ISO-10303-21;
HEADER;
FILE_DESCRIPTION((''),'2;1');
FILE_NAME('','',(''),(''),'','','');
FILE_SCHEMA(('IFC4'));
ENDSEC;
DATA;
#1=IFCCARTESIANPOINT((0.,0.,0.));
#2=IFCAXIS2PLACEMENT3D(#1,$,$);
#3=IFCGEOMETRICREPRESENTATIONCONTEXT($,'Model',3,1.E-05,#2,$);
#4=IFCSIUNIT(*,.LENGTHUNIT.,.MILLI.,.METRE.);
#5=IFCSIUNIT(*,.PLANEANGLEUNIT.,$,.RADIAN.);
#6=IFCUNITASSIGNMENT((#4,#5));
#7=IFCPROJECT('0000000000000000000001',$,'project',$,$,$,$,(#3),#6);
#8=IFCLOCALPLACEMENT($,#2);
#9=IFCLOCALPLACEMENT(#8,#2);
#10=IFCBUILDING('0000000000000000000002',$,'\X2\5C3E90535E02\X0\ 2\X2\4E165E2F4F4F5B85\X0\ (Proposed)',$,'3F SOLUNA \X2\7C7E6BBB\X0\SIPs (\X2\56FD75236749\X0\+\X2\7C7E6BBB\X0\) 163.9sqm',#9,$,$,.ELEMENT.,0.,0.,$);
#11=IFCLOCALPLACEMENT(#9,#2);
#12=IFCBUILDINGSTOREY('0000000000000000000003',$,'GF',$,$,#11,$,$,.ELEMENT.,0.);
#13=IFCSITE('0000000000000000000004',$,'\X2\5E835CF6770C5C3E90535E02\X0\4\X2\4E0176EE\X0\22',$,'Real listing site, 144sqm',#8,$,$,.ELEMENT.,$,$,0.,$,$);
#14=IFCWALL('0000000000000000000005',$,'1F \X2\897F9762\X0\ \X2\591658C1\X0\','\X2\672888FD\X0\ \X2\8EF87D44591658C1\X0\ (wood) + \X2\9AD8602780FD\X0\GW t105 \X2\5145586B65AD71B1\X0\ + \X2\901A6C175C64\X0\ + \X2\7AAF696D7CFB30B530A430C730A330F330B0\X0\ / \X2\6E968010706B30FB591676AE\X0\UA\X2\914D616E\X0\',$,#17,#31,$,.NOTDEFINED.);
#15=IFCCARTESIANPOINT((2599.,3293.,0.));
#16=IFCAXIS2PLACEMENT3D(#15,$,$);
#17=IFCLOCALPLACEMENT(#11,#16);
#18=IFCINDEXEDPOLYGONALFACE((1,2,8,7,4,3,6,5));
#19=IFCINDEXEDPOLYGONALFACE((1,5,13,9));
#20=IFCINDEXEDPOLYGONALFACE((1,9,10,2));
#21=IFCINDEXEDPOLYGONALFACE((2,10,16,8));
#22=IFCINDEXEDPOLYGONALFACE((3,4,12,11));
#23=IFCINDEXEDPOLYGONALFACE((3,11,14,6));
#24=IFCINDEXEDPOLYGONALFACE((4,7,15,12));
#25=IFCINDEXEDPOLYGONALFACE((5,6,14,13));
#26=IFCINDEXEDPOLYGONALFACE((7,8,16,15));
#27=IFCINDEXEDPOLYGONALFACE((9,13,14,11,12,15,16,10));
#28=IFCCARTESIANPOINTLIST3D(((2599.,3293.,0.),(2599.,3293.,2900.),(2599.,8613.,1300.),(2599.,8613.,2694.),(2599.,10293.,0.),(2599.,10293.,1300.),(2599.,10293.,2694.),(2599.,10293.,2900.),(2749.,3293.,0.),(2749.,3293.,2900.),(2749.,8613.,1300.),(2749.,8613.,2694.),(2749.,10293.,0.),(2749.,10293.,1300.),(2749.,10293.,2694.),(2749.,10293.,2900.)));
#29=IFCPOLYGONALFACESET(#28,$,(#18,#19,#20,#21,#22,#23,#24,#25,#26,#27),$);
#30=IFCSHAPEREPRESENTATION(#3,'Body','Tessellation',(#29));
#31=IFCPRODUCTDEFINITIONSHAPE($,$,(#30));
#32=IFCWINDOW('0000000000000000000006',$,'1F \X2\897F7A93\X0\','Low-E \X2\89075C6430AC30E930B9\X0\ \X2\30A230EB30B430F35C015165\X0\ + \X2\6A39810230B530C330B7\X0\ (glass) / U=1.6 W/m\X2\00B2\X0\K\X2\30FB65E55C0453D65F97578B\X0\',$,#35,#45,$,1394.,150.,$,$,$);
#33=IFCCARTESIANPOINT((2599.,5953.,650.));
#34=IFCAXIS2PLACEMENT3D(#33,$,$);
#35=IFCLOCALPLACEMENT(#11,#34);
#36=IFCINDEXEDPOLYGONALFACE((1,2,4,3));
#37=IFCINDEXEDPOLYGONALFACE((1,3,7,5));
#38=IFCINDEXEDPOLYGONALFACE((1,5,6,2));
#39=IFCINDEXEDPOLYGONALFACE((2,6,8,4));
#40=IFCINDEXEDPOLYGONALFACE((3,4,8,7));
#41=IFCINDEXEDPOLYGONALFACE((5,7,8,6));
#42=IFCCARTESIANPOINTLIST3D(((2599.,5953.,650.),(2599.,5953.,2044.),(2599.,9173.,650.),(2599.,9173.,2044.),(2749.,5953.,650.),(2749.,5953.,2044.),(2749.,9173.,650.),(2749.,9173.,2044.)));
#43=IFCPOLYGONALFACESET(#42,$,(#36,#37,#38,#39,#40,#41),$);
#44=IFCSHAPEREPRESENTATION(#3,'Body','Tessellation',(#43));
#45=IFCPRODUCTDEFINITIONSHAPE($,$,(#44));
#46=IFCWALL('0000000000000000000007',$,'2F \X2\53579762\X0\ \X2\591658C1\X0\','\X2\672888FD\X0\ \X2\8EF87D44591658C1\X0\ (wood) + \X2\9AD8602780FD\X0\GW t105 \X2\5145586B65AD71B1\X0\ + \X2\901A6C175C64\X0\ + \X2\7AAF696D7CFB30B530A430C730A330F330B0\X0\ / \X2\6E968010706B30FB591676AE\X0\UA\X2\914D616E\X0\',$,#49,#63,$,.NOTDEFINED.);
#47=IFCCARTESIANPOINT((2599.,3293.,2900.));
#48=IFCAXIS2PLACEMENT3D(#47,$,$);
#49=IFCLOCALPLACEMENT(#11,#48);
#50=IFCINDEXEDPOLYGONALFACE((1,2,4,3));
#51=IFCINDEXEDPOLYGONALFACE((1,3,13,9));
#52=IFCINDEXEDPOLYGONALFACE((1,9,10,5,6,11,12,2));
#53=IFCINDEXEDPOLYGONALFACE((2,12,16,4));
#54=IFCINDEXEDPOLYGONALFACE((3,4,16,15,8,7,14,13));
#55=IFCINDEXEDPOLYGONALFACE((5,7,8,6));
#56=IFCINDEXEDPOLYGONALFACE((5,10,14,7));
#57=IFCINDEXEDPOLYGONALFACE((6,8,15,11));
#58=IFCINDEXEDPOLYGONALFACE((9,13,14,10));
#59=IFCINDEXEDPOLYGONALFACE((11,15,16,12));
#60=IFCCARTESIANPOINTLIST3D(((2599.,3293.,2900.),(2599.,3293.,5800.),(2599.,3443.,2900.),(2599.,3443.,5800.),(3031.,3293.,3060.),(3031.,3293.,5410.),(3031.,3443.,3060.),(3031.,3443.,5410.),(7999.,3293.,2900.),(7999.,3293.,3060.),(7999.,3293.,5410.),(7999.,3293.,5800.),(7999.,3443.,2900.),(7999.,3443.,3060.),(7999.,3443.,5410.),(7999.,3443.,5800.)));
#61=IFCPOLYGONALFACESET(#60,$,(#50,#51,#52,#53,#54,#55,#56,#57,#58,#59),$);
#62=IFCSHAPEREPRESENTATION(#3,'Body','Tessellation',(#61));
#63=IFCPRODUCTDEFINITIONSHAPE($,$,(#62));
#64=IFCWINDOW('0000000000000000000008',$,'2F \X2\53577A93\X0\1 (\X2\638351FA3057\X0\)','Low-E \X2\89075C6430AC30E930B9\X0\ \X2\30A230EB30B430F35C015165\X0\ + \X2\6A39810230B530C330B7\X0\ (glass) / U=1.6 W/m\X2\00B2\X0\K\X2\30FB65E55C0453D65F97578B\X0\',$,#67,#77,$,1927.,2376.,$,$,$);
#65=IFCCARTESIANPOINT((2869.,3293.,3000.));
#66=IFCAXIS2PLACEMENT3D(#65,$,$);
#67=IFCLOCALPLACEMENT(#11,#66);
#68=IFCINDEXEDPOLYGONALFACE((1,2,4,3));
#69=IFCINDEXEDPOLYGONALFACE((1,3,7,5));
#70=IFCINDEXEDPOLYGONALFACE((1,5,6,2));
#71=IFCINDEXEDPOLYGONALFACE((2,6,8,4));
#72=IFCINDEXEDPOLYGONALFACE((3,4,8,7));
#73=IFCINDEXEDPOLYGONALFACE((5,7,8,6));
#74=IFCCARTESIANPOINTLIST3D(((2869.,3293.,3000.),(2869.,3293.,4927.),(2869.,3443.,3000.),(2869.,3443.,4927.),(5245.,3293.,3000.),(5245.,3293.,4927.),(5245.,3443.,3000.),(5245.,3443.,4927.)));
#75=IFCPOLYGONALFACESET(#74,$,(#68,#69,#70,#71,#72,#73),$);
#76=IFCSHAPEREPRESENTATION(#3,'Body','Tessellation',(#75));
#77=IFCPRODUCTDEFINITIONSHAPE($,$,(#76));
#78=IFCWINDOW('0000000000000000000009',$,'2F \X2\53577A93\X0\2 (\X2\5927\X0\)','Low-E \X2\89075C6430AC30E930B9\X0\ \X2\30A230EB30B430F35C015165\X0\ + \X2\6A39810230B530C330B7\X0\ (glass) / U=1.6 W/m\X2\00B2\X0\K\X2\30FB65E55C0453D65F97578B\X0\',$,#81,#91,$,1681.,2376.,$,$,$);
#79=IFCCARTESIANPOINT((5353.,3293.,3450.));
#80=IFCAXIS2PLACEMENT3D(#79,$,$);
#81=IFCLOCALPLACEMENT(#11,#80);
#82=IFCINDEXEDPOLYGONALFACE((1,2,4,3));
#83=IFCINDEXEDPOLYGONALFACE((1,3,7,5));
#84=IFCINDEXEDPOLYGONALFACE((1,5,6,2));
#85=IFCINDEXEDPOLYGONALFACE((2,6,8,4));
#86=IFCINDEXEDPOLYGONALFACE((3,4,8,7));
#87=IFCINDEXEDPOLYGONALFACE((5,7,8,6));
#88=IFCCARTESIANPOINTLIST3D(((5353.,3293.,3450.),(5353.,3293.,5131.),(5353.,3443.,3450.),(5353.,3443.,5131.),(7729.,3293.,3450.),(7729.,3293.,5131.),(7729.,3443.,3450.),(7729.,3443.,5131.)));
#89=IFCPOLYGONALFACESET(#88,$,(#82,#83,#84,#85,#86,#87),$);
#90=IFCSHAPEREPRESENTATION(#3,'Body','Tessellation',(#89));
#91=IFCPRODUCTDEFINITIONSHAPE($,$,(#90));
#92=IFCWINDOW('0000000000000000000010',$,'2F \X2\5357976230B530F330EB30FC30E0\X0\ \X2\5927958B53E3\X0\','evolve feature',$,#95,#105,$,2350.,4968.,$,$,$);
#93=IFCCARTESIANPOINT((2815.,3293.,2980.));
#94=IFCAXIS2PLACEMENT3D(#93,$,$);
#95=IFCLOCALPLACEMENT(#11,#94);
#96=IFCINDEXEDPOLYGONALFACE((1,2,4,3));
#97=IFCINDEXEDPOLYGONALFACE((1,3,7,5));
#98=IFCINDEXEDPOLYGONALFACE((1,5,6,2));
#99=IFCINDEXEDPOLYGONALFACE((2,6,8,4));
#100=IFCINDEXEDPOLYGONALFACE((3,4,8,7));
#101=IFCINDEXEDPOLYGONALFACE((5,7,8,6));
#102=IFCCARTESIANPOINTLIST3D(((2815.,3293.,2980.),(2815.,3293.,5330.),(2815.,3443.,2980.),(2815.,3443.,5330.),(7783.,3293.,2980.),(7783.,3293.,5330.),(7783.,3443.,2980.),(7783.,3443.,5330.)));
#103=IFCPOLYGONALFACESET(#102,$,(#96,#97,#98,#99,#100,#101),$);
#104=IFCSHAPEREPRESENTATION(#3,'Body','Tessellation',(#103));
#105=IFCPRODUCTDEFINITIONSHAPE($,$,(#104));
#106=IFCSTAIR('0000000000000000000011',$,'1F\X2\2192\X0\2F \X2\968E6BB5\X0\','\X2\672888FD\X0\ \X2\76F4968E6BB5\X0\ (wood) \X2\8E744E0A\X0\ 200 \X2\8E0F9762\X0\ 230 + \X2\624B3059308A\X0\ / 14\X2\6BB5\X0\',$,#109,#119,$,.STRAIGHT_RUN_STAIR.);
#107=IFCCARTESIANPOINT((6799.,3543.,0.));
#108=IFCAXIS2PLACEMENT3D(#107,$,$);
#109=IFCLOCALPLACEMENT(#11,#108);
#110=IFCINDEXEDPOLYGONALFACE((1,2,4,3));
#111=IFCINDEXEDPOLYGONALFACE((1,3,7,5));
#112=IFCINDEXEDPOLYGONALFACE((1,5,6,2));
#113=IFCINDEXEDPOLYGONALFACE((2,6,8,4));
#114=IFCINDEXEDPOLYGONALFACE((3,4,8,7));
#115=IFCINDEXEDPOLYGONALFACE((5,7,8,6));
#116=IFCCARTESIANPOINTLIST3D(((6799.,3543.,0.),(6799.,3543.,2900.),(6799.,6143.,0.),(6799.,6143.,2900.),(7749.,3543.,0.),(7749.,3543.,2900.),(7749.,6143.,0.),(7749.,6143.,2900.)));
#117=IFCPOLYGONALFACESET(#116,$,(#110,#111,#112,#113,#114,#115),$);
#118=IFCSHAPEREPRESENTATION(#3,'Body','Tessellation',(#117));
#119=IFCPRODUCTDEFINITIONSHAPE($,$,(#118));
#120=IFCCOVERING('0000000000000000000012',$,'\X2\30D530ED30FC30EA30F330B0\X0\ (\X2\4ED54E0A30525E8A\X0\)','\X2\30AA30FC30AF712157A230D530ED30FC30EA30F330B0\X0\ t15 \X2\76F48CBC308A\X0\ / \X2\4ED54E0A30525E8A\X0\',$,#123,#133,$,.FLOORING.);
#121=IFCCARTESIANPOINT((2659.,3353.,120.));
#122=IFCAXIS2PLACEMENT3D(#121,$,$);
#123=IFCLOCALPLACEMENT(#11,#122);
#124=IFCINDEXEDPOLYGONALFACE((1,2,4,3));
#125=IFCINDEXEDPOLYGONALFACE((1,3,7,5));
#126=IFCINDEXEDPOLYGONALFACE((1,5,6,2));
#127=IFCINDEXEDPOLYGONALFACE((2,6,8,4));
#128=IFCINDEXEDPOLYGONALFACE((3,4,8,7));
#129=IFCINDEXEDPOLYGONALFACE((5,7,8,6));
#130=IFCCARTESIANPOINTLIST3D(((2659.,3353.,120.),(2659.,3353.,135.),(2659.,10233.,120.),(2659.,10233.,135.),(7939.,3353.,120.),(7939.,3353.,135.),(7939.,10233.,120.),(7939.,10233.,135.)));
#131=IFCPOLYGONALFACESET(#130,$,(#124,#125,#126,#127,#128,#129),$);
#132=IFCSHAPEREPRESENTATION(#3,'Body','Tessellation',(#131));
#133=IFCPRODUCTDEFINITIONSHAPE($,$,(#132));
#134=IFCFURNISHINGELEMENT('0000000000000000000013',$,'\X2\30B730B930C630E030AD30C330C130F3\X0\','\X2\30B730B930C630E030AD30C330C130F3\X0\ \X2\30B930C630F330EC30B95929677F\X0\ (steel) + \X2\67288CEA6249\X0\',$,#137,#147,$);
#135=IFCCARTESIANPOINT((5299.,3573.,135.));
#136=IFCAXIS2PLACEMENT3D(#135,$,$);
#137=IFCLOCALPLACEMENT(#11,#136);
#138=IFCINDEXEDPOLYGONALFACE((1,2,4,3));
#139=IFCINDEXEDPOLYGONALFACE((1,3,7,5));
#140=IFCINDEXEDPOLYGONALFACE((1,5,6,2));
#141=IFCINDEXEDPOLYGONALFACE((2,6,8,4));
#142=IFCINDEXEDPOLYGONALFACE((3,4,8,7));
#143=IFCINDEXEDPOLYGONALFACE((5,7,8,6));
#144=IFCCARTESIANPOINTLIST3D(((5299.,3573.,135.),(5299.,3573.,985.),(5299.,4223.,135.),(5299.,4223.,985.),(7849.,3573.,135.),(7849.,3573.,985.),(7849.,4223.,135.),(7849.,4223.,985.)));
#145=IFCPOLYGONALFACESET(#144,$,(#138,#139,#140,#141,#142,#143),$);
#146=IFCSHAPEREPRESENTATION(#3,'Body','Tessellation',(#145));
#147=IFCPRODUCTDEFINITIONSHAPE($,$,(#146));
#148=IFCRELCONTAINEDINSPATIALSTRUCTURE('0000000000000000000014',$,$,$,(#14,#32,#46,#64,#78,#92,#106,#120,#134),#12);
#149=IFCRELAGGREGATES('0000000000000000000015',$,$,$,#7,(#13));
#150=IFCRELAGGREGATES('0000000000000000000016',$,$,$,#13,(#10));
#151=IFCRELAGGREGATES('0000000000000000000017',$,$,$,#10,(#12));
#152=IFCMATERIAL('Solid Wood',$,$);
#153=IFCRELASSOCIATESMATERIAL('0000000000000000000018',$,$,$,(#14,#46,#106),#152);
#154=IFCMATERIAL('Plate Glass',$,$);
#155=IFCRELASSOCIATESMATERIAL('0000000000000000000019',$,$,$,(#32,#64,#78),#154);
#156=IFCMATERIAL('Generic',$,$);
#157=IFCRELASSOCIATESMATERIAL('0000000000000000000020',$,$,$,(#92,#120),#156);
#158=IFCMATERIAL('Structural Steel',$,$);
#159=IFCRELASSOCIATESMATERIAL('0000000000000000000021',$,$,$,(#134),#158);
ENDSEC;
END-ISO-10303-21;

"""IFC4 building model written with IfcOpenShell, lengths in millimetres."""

from ifc_helpers import new_model, si_unit, frame, frame_2d, origin, place, context, project, spatial, rectangle, extrude, material, element, fill, save


model = new_model("IFC4")

# Units and contexts
model_context = context("Model", 3, precision=1e-05, world=origin())
ifc_project = project(units=[si_unit("LENGTHUNIT", "METRE", prefix="MILLI"), si_unit("PLANEANGLEUNIT", "RADIAN")], contexts=[model_context])

# Site, building, storey
site_placement = place(None, origin())
site = spatial("IfcSite", under=ifc_project, at=site_placement, Name="広島県尾道市4丁目22", ObjectType="Real listing site, 144sqm", CompositionType="ELEMENT", RefElevation=0.0)
building_placement = place(site_placement, origin())
building = spatial("IfcBuilding", under=site, at=building_placement, Name="尾道市 2世帯住宅 (Proposed)", ObjectType="3F SOLUNA 籾殻SIPs (国産杉+籾殻) 163.9sqm", CompositionType="ELEMENT", ElevationOfRefHeight=0.0, ElevationOfTerrain=0.0)
storey_placement = place(building_placement, origin())
storey = spatial("IfcBuildingStorey", under=building, at=storey_placement, Name="GF", CompositionType="ELEMENT", Elevation=0.0)

# Shared definitions
ifc_material_1 = material(Name="Solid Wood")
ifc_material_2 = material(Name="Generic")

# Shared definitions
ifc_material_3 = material(Name="Plate Glass")

# Wall, opening, window
wall_1_placement = place(storey_placement, frame((2599.0, 3293.0, 0.0)))
wall_1 = element("IfcWall", 1, at=wall_1_placement, inside=storey, material=ifc_material_1, Name="1F 西面 外壁", Description="木製 軸組外壁 (wood) + 高性能GW t105 充填断熱 + 通気層 + 窯業系サイディング / 準耐火・外皮UA配慮", PredefinedType="NOTDEFINED", context=model_context, shape_type="SweptSolid", body=[
    extrude(rectangle(XDim=150.0, YDim=7000.0, at=frame_2d((75.0, 3500.0))), frame((2599.0, 3293.0, 0.0)), (0.0, 0.0, 1.0), 2900.0),
])
opening_1_placement = place(storey_placement, frame((2599.0, 5953.0, 650.0)))
opening_1 = element("IfcOpeningElement", 2, at=opening_1_placement, cuts=wall_1, PredefinedType="NOTDEFINED", context=model_context, shape_type="SweptSolid", body=[
    extrude(rectangle(XDim=150.0, YDim=3220.0, at=frame_2d((75.0, 1610.0))), frame((2599.0, 5953.0, 650.0)), (0.0, 0.0, 1.0), 1394.0),
])
window_1_placement = place(storey_placement, frame((2599.0, 5953.0, 650.0)))
window_1 = element("IfcWindow", 3, at=window_1_placement, inside=storey, material=ifc_material_3, Name="1F 西窓", Description="Low-E 複層ガラス アルゴン封入 + 樹脂サッシ (glass) / U=1.6 W/m²K・日射取得型", OverallHeight=1394.0, OverallWidth=150.0, context=model_context, shape_type="SweptSolid", body=[
    extrude(rectangle(XDim=150.0, YDim=3220.0, at=frame_2d((75.0, 1610.0))), frame((2599.0, 5953.0, 650.0)), (0.0, 0.0, 1.0), 1394.0),
])
fill(opening_1, window_1)

# Wall, openings, windows
wall_2_placement = place(storey_placement, frame((2599.0, 3293.0, 2900.0)))
wall_2 = element("IfcWall", 4, at=wall_2_placement, inside=storey, material=ifc_material_1, Name="2F 南面 外壁", Description="木製 軸組外壁 (wood) + 高性能GW t105 充填断熱 + 通気層 + 窯業系サイディング / 準耐火・外皮UA配慮", PredefinedType="NOTDEFINED", context=model_context, shape_type="SweptSolid", body=[
    extrude(rectangle(XDim=5400.0, YDim=150.0, at=frame_2d((2700.0, 75.0))), frame((2599.0, 3293.0, 2900.0)), (0.0, 0.0, 1.0), 2900.0),
])
opening_2_placement = place(storey_placement, frame((2869.0, 3293.0, 3000.0)))
opening_2 = element("IfcOpeningElement", 5, at=opening_2_placement, cuts=wall_2, PredefinedType="NOTDEFINED", context=model_context, shape_type="SweptSolid", body=[
    extrude(rectangle(XDim=2376.0, YDim=150.0, at=frame_2d((1188.0, 75.0))), frame((2869.0, 3293.0, 3000.0)), (0.0, 0.0, 1.0), 1927.0),
])
opening_3_placement = place(storey_placement, frame((5353.0, 3293.0, 3450.0)))
opening_3 = element("IfcOpeningElement", 6, at=opening_3_placement, cuts=wall_2, PredefinedType="NOTDEFINED", context=model_context, shape_type="SweptSolid", body=[
    extrude(rectangle(XDim=2376.0, YDim=150.0, at=frame_2d((1188.0, 75.0))), frame((5353.0, 3293.0, 3450.0)), (0.0, 0.0, 1.0), 1681.0),
])
opening_4_placement = place(storey_placement, frame((2815.0, 3293.0, 2980.0)))
opening_4 = element("IfcOpeningElement", 7, at=opening_4_placement, cuts=wall_2, PredefinedType="NOTDEFINED", context=model_context, shape_type="SweptSolid", body=[
    extrude(rectangle(XDim=4968.0, YDim=150.0, at=frame_2d((2484.0, 75.0))), frame((2815.0, 3293.0, 2980.0)), (0.0, 0.0, 1.0), 2350.0),
])
window_2_placement = place(storey_placement, frame((2869.0, 3293.0, 3000.0)))
window_2 = element("IfcWindow", 8, at=window_2_placement, inside=storey, material=ifc_material_3, Name="2F 南窓1 (掃出し)", Description="Low-E 複層ガラス アルゴン封入 + 樹脂サッシ (glass) / U=1.6 W/m²K・日射取得型", OverallHeight=1927.0, OverallWidth=2376.0, context=model_context, shape_type="SweptSolid", body=[
    extrude(rectangle(XDim=2376.0, YDim=150.0, at=frame_2d((1188.0, 75.0))), frame((2869.0, 3293.0, 3000.0)), (0.0, 0.0, 1.0), 1927.0),
])
fill(opening_2, window_2)
window_3_placement = place(storey_placement, frame((5353.0, 3293.0, 3450.0)))
window_3 = element("IfcWindow", 9, at=window_3_placement, inside=storey, material=ifc_material_3, Name="2F 南窓2 (大)", Description="Low-E 複層ガラス アルゴン封入 + 樹脂サッシ (glass) / U=1.6 W/m²K・日射取得型", OverallHeight=1681.0, OverallWidth=2376.0, context=model_context, shape_type="SweptSolid", body=[
    extrude(rectangle(XDim=2376.0, YDim=150.0, at=frame_2d((1188.0, 75.0))), frame((5353.0, 3293.0, 3450.0)), (0.0, 0.0, 1.0), 1681.0),
])
fill(opening_3, window_3)
window_4_placement = place(storey_placement, frame((2815.0, 3293.0, 2980.0)))
window_4 = element("IfcWindow", 10, at=window_4_placement, inside=storey, material=ifc_material_2, Name="2F 南面サンルーム 大開口", Description="evolve feature", OverallHeight=2350.0, OverallWidth=4968.0, context=model_context, shape_type="SweptSolid", body=[
    extrude(rectangle(XDim=4968.0, YDim=150.0, at=frame_2d((2484.0, 75.0))), frame((2815.0, 3293.0, 2980.0)), (0.0, 0.0, 1.0), 2350.0),
])
fill(opening_4, window_4)

# Stair
stair_placement = place(storey_placement, frame((6799.0, 3543.0, 0.0)))
element("IfcStair", 11, at=stair_placement, inside=storey, material=ifc_material_1, Name="1F→2F 階段", Description="木製 直階段 (wood) 蹴上 200 踏面 230 + 手すり / 14段", PredefinedType="STRAIGHT_RUN_STAIR", context=model_context, shape_type="SweptSolid", body=[
    extrude(rectangle(XDim=950.0, YDim=2600.0, at=frame_2d((475.0, 1300.0))), frame((6799.0, 3543.0, 0.0)), (0.0, 0.0, 1.0), 2900.0),
])

# Covering
covering_placement = place(storey_placement, frame((2659.0, 3353.0, 120.0)))
element("IfcCovering", 12, at=covering_placement, inside=storey, material=ifc_material_2, Name="フローリング (仕上げ床)", Description="オーク無垢フローリング t15 直貼り / 仕上げ床", PredefinedType="FLOORING", context=model_context, shape_type="SweptSolid", body=[
    extrude(rectangle(XDim=5280.0, YDim=6880.0, at=frame_2d((2640.0, 3440.0))), frame((2659.0, 3353.0, 120.0)), (0.0, 0.0, 1.0), 15.0),
])

# Furnishing element
ifc_material_4 = material(Name="Structural Steel")
furnishing_placement = place(storey_placement, frame((5299.0, 3573.0, 135.0)))
element("IfcFurnishingElement", 13, at=furnishing_placement, inside=storey, material=ifc_material_4, Name="システムキッチン", Description="システムキッチン ステンレス天板 (steel) + 木質扉", context=model_context, shape_type="SweptSolid", body=[
    extrude(rectangle(XDim=2550.0, YDim=650.0, at=frame_2d((1275.0, 325.0))), frame((5299.0, 3573.0, 135.0)), (0.0, 0.0, 1.0), 850.0),
])

save(model, "model.ifc")
